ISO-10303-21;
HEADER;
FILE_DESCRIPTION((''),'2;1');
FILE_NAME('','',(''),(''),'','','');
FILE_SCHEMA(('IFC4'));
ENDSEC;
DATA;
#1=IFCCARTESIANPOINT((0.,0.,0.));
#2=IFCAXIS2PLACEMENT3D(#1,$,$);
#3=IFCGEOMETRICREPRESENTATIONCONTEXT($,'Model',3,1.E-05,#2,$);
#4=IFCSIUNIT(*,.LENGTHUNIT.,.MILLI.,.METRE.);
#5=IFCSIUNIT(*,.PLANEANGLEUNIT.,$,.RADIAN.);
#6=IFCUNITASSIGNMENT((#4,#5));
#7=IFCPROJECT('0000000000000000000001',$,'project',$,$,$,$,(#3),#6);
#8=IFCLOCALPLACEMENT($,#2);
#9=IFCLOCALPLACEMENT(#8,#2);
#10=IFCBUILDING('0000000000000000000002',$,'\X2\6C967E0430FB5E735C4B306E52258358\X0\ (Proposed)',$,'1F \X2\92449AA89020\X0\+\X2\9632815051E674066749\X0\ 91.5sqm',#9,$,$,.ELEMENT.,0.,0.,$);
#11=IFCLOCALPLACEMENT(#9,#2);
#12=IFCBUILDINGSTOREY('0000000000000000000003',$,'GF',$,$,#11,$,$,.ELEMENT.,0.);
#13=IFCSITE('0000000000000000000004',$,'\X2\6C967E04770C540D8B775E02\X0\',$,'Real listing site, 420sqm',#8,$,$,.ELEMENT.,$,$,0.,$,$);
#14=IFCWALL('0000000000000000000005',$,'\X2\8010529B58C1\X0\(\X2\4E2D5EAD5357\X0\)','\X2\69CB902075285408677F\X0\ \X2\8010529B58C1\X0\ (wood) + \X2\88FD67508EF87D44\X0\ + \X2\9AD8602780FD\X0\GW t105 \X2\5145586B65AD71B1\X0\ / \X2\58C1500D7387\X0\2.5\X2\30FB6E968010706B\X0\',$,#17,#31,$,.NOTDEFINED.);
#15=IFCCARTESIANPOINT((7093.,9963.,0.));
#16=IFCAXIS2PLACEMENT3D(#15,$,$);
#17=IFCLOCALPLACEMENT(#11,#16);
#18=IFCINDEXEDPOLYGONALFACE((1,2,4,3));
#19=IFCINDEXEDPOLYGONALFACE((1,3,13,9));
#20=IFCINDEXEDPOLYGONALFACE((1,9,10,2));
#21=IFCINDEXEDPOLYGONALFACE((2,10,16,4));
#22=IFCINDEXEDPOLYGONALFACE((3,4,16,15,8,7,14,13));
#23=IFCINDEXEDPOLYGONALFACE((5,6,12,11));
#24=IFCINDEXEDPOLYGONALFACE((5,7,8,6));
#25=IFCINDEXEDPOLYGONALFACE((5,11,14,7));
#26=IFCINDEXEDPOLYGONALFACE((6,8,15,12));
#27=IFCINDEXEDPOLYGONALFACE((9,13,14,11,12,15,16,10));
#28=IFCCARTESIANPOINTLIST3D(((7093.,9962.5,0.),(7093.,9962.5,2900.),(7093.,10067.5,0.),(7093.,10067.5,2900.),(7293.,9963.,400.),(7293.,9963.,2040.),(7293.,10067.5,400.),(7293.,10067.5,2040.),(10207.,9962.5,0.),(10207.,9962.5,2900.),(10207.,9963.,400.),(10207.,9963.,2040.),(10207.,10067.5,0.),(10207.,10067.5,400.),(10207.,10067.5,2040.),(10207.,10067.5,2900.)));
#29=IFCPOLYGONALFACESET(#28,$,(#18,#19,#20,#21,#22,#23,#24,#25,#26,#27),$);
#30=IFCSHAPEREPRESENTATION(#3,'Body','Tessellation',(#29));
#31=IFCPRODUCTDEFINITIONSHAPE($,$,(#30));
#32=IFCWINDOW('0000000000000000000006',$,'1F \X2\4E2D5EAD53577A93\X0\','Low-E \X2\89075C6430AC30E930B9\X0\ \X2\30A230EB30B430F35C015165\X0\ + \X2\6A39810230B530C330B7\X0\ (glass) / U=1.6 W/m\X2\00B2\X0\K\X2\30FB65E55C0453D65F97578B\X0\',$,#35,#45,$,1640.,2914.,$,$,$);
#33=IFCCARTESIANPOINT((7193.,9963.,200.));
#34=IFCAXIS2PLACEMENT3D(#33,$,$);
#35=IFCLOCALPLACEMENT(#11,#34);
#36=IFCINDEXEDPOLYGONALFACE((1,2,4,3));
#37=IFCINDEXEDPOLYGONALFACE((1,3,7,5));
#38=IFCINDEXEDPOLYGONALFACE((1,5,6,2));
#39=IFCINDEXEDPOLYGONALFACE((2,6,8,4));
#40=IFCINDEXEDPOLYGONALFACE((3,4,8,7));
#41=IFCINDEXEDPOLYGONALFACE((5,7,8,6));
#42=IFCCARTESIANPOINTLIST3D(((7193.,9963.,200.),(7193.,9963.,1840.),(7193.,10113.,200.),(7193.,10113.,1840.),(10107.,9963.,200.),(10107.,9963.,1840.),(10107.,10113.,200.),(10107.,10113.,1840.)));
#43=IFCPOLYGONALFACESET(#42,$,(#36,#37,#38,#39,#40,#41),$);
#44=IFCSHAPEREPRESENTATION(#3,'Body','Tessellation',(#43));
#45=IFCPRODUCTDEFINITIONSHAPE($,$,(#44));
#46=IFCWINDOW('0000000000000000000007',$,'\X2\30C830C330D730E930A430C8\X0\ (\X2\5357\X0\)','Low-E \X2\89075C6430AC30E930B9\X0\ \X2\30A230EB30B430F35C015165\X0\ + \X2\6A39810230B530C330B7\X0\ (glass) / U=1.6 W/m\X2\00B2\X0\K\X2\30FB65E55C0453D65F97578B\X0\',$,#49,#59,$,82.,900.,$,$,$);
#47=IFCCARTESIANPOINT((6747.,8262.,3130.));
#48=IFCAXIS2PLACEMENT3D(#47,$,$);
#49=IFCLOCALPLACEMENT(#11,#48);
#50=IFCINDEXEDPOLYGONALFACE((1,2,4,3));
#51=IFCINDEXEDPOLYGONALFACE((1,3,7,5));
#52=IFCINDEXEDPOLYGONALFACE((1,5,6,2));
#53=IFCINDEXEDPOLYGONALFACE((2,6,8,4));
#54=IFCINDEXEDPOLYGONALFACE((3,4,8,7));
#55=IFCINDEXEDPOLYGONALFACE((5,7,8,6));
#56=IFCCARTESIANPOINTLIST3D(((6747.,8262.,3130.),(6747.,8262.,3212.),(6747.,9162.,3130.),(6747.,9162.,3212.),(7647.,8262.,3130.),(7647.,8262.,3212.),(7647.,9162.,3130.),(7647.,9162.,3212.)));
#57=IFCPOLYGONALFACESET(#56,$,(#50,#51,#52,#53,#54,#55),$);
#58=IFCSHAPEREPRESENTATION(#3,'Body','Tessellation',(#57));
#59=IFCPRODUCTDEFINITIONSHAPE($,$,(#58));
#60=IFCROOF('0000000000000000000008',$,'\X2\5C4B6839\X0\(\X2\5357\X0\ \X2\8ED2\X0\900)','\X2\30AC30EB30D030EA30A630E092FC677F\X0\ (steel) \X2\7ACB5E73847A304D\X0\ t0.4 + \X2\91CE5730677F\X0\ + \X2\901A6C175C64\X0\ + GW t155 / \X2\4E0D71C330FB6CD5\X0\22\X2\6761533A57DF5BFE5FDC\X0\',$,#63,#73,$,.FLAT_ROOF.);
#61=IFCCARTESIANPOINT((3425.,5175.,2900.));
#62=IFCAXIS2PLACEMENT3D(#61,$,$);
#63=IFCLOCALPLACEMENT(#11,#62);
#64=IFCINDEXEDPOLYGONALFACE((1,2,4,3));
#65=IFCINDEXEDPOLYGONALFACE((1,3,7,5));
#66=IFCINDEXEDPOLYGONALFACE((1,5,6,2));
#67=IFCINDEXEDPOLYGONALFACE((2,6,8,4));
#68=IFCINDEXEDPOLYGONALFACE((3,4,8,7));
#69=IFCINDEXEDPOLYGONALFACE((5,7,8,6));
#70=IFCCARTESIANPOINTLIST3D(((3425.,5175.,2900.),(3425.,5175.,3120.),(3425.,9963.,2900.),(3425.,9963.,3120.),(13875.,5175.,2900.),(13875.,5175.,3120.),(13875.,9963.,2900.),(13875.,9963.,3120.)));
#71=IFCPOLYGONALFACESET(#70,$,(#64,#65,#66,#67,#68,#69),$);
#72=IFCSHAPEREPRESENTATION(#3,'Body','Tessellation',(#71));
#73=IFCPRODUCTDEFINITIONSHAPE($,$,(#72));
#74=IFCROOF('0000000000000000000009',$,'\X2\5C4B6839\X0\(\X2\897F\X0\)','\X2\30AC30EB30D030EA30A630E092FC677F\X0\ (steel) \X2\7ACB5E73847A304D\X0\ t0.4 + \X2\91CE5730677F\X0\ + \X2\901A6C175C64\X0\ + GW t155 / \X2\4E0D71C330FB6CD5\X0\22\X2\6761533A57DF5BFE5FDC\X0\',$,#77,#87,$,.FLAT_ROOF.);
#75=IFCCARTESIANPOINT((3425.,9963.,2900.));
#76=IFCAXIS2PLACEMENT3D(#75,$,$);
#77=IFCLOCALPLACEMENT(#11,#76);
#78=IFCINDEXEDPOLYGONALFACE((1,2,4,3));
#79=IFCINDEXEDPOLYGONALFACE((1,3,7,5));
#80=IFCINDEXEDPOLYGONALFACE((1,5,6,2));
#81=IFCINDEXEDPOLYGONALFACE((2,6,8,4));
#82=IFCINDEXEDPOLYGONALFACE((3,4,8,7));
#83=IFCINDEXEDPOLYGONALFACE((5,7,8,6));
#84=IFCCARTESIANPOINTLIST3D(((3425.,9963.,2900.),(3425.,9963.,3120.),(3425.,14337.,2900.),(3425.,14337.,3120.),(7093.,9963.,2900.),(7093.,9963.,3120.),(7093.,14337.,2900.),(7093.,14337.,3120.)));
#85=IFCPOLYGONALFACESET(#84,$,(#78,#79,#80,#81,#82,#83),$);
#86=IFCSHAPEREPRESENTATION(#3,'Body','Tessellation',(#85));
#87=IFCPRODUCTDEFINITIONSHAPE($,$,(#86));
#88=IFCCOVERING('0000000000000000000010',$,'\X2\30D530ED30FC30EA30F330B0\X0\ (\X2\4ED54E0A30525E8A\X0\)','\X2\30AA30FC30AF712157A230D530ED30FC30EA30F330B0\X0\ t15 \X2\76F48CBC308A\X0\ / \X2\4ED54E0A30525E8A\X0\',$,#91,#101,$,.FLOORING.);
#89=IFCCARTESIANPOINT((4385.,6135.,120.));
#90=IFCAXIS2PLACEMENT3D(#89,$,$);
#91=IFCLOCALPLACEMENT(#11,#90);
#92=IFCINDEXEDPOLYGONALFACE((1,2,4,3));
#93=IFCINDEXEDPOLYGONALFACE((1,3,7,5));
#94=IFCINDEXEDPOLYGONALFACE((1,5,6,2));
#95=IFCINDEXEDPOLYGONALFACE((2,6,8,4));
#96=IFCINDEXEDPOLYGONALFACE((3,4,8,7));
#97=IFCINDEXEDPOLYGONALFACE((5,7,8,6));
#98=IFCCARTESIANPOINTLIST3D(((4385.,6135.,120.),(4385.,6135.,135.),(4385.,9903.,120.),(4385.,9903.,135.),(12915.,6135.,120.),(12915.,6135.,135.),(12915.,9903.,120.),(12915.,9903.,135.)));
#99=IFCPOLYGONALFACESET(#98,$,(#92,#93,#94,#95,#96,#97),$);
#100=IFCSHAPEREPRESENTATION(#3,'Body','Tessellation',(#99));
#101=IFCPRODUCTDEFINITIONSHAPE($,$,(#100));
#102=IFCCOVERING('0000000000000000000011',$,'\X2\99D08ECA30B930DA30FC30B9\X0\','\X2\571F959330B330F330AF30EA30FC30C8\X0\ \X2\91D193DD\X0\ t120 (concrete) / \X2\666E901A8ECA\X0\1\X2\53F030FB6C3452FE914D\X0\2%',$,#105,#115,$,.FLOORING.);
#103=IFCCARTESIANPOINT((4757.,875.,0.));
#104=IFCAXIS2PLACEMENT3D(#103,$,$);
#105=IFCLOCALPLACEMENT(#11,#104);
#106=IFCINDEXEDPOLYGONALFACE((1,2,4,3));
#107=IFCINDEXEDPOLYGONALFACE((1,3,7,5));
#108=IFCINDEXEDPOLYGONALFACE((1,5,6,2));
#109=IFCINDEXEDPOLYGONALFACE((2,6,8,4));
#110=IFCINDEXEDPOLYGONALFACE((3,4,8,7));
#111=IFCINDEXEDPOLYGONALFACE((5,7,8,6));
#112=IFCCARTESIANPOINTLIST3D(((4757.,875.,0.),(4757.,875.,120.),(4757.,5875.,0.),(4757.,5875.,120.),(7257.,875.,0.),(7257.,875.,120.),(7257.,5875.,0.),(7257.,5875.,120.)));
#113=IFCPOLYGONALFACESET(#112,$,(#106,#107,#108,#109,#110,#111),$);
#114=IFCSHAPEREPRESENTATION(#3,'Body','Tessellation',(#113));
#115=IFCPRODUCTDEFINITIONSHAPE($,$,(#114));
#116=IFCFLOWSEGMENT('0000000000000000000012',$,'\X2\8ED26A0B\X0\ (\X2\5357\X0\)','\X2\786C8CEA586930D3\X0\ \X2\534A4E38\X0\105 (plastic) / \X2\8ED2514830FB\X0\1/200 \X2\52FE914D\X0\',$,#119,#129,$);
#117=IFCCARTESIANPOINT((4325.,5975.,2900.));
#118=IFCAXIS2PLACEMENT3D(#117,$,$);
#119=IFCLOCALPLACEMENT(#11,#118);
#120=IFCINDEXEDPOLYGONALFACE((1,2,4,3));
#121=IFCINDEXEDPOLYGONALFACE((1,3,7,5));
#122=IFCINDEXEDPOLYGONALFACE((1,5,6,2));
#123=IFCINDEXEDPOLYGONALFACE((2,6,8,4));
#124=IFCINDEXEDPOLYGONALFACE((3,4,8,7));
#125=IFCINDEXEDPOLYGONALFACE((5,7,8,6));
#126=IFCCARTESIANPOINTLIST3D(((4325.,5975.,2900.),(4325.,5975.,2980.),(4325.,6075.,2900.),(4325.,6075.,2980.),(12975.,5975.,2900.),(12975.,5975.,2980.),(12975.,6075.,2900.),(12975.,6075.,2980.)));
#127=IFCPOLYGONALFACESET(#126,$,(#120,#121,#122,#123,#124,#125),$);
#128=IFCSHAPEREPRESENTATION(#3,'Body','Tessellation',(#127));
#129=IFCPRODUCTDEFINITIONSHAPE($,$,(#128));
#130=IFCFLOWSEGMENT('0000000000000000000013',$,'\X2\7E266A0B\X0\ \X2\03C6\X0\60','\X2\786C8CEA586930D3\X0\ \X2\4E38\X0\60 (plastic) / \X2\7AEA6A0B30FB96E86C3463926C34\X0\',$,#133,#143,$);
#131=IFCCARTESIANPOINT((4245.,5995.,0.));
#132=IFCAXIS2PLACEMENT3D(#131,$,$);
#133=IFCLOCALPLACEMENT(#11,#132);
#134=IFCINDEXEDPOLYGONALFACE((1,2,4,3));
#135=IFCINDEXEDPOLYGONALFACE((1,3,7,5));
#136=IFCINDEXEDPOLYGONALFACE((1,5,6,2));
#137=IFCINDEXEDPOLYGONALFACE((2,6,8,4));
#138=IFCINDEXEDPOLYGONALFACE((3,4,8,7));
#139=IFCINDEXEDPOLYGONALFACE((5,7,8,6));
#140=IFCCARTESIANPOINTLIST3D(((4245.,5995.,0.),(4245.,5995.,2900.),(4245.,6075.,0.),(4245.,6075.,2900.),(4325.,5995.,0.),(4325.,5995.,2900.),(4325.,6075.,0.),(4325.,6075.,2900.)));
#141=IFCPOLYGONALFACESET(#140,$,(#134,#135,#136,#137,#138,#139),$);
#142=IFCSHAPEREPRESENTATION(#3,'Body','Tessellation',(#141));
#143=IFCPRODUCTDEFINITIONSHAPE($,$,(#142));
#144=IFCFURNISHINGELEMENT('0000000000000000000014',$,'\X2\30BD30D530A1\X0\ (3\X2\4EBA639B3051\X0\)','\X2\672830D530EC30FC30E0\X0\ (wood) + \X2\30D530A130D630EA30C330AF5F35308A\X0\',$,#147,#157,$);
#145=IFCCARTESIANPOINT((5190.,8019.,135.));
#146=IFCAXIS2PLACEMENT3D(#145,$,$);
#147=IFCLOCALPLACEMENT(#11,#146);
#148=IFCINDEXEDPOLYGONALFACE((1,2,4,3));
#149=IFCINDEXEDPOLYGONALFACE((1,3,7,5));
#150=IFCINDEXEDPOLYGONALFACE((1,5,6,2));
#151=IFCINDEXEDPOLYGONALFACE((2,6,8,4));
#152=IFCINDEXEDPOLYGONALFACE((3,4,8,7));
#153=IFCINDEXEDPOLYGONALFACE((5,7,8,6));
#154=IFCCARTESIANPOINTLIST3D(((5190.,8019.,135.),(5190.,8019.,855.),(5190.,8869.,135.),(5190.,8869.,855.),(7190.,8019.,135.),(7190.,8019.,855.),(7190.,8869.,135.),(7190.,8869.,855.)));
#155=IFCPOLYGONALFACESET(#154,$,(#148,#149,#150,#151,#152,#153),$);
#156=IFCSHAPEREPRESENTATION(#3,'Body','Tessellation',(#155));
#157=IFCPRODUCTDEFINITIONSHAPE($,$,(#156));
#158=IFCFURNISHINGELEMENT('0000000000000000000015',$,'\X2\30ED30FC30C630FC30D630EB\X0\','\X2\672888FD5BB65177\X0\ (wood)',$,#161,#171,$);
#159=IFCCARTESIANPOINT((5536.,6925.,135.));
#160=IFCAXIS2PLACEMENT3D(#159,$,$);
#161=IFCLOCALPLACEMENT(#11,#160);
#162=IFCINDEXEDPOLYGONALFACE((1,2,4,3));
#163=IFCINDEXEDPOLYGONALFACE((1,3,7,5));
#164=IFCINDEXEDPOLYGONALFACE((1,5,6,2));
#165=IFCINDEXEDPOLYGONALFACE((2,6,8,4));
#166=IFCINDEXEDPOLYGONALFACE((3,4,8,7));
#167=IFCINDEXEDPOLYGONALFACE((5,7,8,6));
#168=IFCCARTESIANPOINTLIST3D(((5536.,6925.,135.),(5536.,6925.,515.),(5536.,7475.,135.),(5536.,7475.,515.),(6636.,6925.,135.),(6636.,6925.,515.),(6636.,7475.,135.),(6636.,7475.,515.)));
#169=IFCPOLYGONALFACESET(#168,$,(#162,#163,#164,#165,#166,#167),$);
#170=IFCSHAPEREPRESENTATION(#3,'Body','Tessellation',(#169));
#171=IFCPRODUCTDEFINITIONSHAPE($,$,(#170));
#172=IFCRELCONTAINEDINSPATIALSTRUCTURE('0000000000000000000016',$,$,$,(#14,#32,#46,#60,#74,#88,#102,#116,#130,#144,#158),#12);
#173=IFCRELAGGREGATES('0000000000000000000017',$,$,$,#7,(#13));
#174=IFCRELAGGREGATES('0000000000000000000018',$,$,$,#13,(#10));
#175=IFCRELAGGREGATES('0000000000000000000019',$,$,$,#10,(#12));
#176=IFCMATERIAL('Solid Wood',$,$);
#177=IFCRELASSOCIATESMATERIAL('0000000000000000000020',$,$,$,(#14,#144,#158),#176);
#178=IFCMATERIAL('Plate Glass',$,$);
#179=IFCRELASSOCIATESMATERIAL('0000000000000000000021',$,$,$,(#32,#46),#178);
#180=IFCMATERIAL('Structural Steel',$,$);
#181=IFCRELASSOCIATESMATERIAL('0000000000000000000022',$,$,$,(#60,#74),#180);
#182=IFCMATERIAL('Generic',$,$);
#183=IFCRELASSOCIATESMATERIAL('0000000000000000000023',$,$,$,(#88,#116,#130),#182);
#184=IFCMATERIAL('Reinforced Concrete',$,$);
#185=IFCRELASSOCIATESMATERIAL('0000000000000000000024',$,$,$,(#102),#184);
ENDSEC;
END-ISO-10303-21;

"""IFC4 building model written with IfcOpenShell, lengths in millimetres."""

from ifc_helpers import new_model, si_unit, frame, frame_2d, origin, place, context, project, spatial, rectangle, extrude, material, element, fill, save


model = new_model("IFC4")

# Units and contexts
model_context = context("Model", 3, precision=1e-05, world=origin())
ifc_project = project(units=[si_unit("LENGTHUNIT", "METRE", prefix="MILLI"), si_unit("PLANEANGLEUNIT", "RADIAN")], contexts=[model_context])

# Site, building, storey
site_placement = place(None, origin())
site = spatial("IfcSite", under=ifc_project, at=site_placement, Name="沖縄県名護市", ObjectType="Real listing site, 420sqm", CompositionType="ELEMENT", RefElevation=0.0)
building_placement = place(site_placement, origin())
building = spatial("IfcBuilding", under=site, at=building_placement, Name="沖縄・平屋の別荘 (Proposed)", ObjectType="1F 鉄骨造+防腐処理杉 91.5sqm", CompositionType="ELEMENT", ElevationOfRefHeight=0.0, ElevationOfTerrain=0.0)
storey_placement = place(building_placement, origin())
storey = spatial("IfcBuildingStorey", under=building, at=storey_placement, Name="GF", CompositionType="ELEMENT", Elevation=0.0)

# Shared definitions
ifc_material_1 = material(Name="Solid Wood")

# Shared definitions
ifc_material_2 = material(Name="Reinforced Concrete")

# Shared definitions
ifc_material_3 = material(Name="Plate Glass")

# Wall, opening, window
wall_1_placement = place(storey_placement, frame((7093.0, 9963.0, 0.0)))
wall_1 = element("IfcWall", 1, at=wall_1_placement, inside=storey, material=ifc_material_1, Name="耐力壁(中庭南)", Description="構造用合板 耐力壁 (wood) + 製材軸組 + 高性能GW t105 充填断熱 / 壁倍率2.5・準耐火", PredefinedType="NOTDEFINED", context=model_context, shape_type="SweptSolid", body=[
    extrude(rectangle(XDim=3114.0, YDim=105.0, at=frame_2d((1557.0, 52.0))), frame((7093.0, 9963.0, 0.0)), (0.0, 0.0, 1.0), 2900.0),
])
opening_1_placement = place(storey_placement, frame((7193.0, 9963.0, 200.0)))
opening_1 = element("IfcOpeningElement", 2, at=opening_1_placement, cuts=wall_1, PredefinedType="NOTDEFINED", context=model_context, shape_type="SweptSolid", body=[
    extrude(rectangle(XDim=2914.0, YDim=150.0, at=frame_2d((1457.0, 75.0))), frame((7193.0, 9963.0, 200.0)), (0.0, 0.0, 1.0), 1640.0),
])
window_1_placement = place(storey_placement, frame((7193.0, 9963.0, 200.0)))
window_1 = element("IfcWindow", 3, at=window_1_placement, inside=storey, material=ifc_material_3, Name="1F 中庭南窓", Description="Low-E 複層ガラス アルゴン封入 + 樹脂サッシ (glass) / U=1.6 W/m²K・日射取得型", OverallHeight=1640.0, OverallWidth=2914.0, context=model_context, shape_type="SweptSolid", body=[
    extrude(rectangle(XDim=2914.0, YDim=150.0, at=frame_2d((1457.0, 75.0))), frame((7193.0, 9963.0, 200.0)), (0.0, 0.0, 1.0), 1640.0),
])
fill(opening_1, window_1)

# Window
window_2_placement = place(storey_placement, frame((6747.0, 8262.0, 3130.0)))
element("IfcWindow", 4, at=window_2_placement, inside=storey, material=ifc_material_3, Name="トップライト (南)", Description="Low-E 複層ガラス アルゴン封入 + 樹脂サッシ (glass) / U=1.6 W/m²K・日射取得型", OverallHeight=82.0, OverallWidth=900.0, context=model_context, shape_type="SweptSolid", body=[
    extrude(rectangle(XDim=900.0, YDim=900.0, at=frame_2d((450.0, 450.0))), frame((6747.0, 8262.0, 3130.0)), (0.0, 0.0, 1.0), 82.0),
])

# Roofs
ifc_material_4 = material(Name="Structural Steel")
roof_1_placement = place(storey_placement, frame((3425.0, 5175.0, 2900.0)))
element("IfcRoof", 5, at=roof_1_placement, inside=storey, material=ifc_material_4, Name="屋根(南 軒900)", Description="ガルバリウム鋼板 (steel) 立平葺き t0.4 + 野地板 + 通気層 + GW t155 / 不燃・法22条区域対応", PredefinedType="FLAT_ROOF", context=model_context, shape_type="SweptSolid", body=[
    extrude(rectangle(XDim=10450.0, YDim=4788.0, at=frame_2d((5225.0, 2394.0))), frame((3425.0, 5175.0, 2900.0)), (0.0, 0.0, 1.0), 220.0),
])
roof_2_placement = place(storey_placement, frame((3425.0, 9963.0, 2900.0)))
element("IfcRoof", 6, at=roof_2_placement, inside=storey, material=ifc_material_4, Name="屋根(西)", Description="ガルバリウム鋼板 (steel) 立平葺き t0.4 + 野地板 + 通気層 + GW t155 / 不燃・法22条区域対応", PredefinedType="FLAT_ROOF", context=model_context, shape_type="SweptSolid", body=[
    extrude(rectangle(XDim=3668.0, YDim=4374.0, at=frame_2d((1834.0, 2187.0))), frame((3425.0, 9963.0, 2900.0)), (0.0, 0.0, 1.0), 220.0),
])

# Coverings
ifc_material_5 = material(Name="Generic")
covering_1_placement = place(storey_placement, frame((4385.0, 6135.0, 120.0)))
element("IfcCovering", 7, at=covering_1_placement, inside=storey, material=ifc_material_5, Name="フローリング (仕上げ床)", Description="オーク無垢フローリング t15 直貼り / 仕上げ床", PredefinedType="FLOORING", context=model_context, shape_type="SweptSolid", body=[
    extrude(rectangle(XDim=8530.0, YDim=3768.0, at=frame_2d((4265.0, 1884.0))), frame((4385.0, 6135.0, 120.0)), (0.0, 0.0, 1.0), 15.0),
])
covering_2_placement = place(storey_placement, frame((4757.0, 875.0, 0.0)))
element("IfcCovering", 8, at=covering_2_placement, inside=storey, material=ifc_material_2, Name="駐車スペース", Description="土間コンクリート 金鏝 t120 (concrete) / 普通車1台・水勾配2%", PredefinedType="FLOORING", context=model_context, shape_type="SweptSolid", body=[
    extrude(rectangle(XDim=2500.0, YDim=5000.0, at=frame_2d((1250.0, 2500.0))), frame((4757.0, 875.0, 0.0)), (0.0, 0.0, 1.0), 120.0),
])

# Flow segments
flow_segment_1_placement = place(storey_placement, frame((4325.0, 5975.0, 2900.0)))
element("IfcFlowSegment", 9, at=flow_segment_1_placement, inside=storey, material=ifc_material_5, Name="軒樋 (南)", Description="硬質塩ビ 半丸105 (plastic) / 軒先・1/200 勾配", context=model_context, shape_type="SweptSolid", body=[
    extrude(rectangle(XDim=8650.0, YDim=100.0, at=frame_2d((4325.0, 50.0))), frame((4325.0, 5975.0, 2900.0)), (0.0, 0.0, 1.0), 80.0),
])
flow_segment_2_placement = place(storey_placement, frame((4245.0, 5995.0, 0.0)))
element("IfcFlowSegment", 10, at=flow_segment_2_placement, inside=storey, material=ifc_material_5, Name="縦樋 φ60", Description="硬質塩ビ 丸60 (plastic) / 竪樋・雨水排水", context=model_context, shape_type="SweptSolid", body=[
    extrude(rectangle(XDim=80.0, YDim=80.0, at=frame_2d((40.0, 40.0))), frame((4245.0, 5995.0, 0.0)), (0.0, 0.0, 1.0), 2900.0),
])

# Furnishing elements
furnishing_1_placement = place(storey_placement, frame((5190.0, 8019.0, 135.0)))
element("IfcFurnishingElement", 11, at=furnishing_1_placement, inside=storey, material=ifc_material_1, Name="ソファ (3人掛け)", Description="木フレーム (wood) + ファブリック張り", context=model_context, shape_type="SweptSolid", body=[
    extrude(rectangle(XDim=2000.0, YDim=850.0, at=frame_2d((1000.0, 425.0))), frame((5190.0, 8019.0, 135.0)), (0.0, 0.0, 1.0), 720.0),
])
furnishing_2_placement = place(storey_placement, frame((5536.0, 6925.0, 135.0)))
element("IfcFurnishingElement", 12, at=furnishing_2_placement, inside=storey, material=ifc_material_1, Name="ローテーブル", Description="木製家具 (wood)", context=model_context, shape_type="SweptSolid", body=[
    extrude(rectangle(XDim=1100.0, YDim=550.0, at=frame_2d((550.0, 275.0))), frame((5536.0, 6925.0, 135.0)), (0.0, 0.0, 1.0), 380.0),
])

save(model, "model.ifc")
